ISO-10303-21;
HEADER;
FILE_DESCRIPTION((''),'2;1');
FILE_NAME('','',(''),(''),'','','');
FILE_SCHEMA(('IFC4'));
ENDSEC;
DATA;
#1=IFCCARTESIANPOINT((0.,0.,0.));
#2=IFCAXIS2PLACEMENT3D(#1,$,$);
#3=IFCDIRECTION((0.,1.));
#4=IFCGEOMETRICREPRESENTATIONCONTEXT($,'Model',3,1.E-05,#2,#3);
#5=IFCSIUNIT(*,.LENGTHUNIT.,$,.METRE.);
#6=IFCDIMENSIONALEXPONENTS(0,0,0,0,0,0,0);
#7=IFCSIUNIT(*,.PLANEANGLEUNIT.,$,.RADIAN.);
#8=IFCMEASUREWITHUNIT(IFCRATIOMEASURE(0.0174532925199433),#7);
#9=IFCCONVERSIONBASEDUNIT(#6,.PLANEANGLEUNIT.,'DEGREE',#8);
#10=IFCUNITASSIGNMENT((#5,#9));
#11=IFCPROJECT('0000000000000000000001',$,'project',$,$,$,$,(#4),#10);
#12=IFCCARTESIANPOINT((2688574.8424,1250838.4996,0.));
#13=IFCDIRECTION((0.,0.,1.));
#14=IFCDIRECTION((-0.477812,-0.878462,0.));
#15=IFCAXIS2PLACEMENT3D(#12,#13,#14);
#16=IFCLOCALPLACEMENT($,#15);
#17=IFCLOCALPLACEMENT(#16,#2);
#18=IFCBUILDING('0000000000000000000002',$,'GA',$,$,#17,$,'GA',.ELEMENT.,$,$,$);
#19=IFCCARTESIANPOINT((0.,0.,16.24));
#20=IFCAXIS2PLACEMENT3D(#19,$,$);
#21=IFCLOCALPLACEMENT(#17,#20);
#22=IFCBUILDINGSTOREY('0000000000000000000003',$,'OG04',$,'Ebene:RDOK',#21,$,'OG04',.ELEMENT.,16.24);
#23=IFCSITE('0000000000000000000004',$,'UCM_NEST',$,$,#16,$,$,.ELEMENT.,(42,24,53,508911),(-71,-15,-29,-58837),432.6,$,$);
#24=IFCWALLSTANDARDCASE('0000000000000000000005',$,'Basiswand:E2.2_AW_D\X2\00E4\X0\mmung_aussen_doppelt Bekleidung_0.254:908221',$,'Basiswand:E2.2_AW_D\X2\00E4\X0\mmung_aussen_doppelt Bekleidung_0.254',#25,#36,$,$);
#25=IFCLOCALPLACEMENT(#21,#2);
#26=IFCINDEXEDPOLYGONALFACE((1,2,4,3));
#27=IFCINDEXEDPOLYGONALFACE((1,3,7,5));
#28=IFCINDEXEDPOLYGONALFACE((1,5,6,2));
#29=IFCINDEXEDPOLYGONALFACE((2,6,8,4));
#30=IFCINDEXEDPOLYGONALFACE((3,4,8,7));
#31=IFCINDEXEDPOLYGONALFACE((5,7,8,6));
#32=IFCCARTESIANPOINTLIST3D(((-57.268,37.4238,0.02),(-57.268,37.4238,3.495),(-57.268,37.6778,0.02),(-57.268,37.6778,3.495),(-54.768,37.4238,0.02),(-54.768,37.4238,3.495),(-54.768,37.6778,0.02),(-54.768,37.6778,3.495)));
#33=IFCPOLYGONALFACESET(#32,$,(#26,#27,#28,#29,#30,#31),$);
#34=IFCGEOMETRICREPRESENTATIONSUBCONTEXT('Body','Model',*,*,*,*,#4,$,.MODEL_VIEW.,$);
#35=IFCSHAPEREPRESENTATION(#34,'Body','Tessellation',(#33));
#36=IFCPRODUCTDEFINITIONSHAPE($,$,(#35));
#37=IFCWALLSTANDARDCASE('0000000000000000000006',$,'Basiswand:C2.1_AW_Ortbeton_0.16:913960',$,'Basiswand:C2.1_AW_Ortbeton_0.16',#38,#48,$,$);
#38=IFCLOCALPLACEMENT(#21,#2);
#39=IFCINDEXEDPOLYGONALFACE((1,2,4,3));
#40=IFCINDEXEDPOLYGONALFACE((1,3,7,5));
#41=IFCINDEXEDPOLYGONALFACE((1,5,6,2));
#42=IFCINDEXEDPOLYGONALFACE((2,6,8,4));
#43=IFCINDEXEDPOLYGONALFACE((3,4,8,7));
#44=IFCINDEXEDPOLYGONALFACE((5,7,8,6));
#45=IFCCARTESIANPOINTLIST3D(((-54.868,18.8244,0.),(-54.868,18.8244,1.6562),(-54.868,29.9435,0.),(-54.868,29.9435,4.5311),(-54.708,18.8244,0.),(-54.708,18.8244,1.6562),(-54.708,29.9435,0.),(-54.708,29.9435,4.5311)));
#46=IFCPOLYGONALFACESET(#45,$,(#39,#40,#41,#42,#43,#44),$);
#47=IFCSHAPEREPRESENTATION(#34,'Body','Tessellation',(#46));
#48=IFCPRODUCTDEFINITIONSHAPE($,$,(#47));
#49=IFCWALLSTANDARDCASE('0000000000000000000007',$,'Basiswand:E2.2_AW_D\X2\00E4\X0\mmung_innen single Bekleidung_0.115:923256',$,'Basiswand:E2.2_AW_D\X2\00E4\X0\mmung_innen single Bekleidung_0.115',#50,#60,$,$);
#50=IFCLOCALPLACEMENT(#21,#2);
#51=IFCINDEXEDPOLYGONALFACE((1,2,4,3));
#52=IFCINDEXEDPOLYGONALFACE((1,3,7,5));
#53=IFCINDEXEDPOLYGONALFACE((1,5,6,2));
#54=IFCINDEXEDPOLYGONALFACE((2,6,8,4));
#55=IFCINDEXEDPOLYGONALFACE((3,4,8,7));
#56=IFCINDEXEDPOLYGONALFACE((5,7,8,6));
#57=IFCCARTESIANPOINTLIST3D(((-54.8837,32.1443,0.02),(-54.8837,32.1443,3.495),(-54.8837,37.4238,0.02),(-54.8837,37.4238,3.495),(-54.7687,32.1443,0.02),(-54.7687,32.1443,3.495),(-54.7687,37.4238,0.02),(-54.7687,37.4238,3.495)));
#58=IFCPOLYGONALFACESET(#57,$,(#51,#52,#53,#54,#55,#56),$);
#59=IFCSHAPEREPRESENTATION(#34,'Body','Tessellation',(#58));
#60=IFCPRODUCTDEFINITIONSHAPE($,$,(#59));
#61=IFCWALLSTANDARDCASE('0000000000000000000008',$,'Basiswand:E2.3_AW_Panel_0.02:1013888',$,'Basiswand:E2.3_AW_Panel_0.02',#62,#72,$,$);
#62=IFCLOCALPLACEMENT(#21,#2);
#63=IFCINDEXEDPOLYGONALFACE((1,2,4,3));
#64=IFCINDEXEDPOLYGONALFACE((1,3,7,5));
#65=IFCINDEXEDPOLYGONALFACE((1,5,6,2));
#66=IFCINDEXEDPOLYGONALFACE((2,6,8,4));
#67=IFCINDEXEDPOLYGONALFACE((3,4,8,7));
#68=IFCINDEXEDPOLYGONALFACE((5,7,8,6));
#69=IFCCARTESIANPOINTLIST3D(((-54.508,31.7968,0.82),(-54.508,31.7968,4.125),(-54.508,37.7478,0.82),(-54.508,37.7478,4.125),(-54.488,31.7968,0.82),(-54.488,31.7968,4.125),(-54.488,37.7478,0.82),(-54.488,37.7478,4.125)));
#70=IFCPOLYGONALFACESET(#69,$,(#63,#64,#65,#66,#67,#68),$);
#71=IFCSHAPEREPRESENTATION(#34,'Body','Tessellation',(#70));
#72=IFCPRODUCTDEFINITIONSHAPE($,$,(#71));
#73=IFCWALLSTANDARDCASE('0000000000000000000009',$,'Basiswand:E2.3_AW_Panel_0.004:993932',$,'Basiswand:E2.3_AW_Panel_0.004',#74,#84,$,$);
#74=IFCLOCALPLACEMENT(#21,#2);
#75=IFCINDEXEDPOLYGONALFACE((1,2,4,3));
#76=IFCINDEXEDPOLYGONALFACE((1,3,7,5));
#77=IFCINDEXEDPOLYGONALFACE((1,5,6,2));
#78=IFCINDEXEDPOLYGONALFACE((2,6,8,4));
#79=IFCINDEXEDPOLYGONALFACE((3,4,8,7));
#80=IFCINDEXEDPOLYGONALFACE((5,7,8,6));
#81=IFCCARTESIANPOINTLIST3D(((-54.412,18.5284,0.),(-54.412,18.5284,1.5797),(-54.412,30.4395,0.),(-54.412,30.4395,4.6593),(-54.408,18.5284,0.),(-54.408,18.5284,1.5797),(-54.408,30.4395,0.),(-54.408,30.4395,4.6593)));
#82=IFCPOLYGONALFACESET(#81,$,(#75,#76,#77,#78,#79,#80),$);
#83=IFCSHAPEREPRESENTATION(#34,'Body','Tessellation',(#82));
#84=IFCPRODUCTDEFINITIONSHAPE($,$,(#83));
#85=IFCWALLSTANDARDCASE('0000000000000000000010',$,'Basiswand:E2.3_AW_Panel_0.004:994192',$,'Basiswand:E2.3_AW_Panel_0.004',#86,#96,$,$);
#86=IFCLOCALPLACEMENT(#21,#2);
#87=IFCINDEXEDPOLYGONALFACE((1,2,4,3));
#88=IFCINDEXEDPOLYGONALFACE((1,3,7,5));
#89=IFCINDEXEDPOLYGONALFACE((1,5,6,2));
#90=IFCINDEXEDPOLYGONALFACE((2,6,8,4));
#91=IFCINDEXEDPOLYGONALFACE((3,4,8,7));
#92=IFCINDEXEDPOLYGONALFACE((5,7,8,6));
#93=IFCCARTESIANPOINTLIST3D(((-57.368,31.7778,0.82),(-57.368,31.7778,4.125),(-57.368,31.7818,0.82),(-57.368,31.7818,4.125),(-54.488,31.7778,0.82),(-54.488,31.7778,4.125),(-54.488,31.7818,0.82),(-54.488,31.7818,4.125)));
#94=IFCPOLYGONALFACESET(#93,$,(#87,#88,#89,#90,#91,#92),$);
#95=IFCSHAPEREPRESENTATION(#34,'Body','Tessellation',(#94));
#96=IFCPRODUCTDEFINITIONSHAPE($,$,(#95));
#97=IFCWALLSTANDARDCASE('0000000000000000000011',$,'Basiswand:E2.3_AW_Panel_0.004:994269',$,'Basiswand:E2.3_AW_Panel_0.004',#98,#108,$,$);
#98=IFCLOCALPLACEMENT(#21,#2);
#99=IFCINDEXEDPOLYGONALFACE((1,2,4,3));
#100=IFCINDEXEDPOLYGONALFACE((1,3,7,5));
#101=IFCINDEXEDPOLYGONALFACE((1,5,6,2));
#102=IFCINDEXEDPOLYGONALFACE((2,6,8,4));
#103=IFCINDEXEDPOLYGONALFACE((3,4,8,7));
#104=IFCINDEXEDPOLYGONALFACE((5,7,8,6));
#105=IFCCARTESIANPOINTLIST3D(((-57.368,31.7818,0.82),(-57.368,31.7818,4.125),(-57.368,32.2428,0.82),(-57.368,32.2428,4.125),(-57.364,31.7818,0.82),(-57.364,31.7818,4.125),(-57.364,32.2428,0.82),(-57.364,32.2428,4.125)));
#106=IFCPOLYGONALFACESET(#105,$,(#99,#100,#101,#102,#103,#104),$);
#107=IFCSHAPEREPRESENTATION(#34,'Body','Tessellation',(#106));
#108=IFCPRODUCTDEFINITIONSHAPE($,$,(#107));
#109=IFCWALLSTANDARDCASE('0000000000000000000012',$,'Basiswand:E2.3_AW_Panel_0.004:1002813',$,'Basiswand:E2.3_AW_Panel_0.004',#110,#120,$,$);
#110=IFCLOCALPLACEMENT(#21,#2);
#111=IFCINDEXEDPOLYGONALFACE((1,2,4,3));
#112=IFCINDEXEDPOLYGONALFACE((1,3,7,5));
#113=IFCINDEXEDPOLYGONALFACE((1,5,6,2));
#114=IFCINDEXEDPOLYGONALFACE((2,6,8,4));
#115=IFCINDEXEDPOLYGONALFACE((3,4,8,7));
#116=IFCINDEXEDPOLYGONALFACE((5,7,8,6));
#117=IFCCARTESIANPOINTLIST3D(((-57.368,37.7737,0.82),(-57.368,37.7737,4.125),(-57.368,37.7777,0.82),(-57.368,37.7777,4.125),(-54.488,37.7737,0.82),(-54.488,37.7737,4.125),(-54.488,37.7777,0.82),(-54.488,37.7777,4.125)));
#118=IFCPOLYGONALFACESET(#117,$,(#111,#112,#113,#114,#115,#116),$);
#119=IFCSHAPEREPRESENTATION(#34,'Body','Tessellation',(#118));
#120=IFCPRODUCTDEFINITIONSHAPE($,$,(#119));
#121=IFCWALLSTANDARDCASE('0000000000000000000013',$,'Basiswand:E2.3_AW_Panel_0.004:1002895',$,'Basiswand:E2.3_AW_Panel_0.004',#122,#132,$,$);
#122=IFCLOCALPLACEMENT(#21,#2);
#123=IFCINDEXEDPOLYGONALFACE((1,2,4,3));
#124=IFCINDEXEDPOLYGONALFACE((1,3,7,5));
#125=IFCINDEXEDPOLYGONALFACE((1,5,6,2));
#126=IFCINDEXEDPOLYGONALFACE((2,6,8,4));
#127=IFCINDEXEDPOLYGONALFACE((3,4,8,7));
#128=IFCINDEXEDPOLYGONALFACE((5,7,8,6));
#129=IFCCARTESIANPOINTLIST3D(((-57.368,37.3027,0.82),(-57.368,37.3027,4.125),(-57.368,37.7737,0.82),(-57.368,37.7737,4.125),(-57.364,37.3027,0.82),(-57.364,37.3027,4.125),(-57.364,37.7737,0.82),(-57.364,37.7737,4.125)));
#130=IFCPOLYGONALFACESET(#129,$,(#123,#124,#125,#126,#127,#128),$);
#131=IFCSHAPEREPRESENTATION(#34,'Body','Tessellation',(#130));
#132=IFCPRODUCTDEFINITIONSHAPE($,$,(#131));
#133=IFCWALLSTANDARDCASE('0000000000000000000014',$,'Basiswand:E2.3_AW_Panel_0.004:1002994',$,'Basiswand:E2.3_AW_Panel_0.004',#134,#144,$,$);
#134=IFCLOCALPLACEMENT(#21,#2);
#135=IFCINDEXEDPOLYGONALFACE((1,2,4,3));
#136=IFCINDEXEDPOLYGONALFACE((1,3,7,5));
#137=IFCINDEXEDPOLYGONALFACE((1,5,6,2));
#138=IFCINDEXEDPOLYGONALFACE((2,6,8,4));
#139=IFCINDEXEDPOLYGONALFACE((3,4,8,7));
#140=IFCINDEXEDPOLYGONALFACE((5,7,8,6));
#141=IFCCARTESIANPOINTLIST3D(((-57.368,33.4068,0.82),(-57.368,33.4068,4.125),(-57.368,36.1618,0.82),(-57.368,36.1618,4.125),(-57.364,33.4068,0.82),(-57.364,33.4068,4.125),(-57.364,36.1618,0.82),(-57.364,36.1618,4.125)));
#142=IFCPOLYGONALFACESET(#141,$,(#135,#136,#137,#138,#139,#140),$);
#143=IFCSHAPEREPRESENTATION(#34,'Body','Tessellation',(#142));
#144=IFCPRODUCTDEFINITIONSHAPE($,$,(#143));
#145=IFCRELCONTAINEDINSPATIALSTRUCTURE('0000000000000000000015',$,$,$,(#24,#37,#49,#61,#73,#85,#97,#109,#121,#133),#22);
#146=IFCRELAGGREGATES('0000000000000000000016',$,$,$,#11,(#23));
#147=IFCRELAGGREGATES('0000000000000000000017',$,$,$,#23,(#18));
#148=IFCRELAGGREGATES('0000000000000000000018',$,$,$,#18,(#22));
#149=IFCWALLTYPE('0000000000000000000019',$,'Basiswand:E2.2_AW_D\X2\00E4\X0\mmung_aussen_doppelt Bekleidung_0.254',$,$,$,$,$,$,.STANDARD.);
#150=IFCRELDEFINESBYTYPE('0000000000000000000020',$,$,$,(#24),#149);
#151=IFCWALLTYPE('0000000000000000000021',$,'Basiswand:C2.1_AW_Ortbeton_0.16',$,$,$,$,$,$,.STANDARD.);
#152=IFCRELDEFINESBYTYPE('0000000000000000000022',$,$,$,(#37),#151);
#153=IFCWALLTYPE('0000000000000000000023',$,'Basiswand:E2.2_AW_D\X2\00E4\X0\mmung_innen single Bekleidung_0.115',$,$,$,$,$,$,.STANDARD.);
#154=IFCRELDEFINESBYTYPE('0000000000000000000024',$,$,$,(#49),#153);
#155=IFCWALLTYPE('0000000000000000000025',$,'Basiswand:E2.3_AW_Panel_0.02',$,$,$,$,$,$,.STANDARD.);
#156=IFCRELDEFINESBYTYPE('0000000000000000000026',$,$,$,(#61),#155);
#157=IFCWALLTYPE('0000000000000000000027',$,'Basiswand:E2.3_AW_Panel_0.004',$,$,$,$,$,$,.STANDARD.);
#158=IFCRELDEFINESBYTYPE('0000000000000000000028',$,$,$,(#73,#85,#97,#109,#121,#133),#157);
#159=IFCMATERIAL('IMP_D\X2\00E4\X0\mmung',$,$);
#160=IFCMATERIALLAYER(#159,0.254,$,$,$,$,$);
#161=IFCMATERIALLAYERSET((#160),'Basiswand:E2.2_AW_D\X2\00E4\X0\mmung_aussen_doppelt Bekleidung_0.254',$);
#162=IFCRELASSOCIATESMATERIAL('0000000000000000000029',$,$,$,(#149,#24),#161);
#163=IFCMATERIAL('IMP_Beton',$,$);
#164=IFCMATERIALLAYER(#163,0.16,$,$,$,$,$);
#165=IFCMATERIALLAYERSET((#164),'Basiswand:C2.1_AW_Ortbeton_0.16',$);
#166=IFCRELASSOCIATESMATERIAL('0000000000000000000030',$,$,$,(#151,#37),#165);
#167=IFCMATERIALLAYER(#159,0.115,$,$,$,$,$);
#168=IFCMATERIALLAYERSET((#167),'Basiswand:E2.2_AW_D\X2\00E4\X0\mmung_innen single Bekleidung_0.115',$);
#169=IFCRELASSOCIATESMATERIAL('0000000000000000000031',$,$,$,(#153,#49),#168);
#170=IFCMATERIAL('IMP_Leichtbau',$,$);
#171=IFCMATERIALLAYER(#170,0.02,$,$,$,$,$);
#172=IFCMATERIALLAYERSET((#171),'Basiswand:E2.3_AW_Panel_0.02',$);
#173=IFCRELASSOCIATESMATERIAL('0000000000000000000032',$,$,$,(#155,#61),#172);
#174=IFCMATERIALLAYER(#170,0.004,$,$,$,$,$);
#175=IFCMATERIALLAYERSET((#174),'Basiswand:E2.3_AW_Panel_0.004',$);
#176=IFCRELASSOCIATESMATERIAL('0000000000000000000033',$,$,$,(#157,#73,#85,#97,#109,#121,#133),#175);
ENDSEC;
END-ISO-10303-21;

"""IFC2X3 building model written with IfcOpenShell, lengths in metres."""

from ifc_helpers import new_model, entity, si_unit, converted_unit, direction, frame, frame_2d, origin, place, context, subcontext, project, spatial, rectangle, extrude, clip, halfspace, material, layer, layer_set, layer_usage, type_object, element, save


model = new_model("IFC2X3")

# Units and contexts
model_context = context("Model", 3, precision=1e-05, world=origin(), true_north=direction((0.0, 1.0)))
body_context = subcontext(model_context, "Body", "Model", "MODEL_VIEW")
ifc_project = project(units=[si_unit("LENGTHUNIT", "METRE"), converted_unit("PLANEANGLEUNIT", "DEGREE", entity("IfcRatioMeasure", 0.0174532925199433), si_unit("PLANEANGLEUNIT", "RADIAN"), dimensions=[0, 0, 0, 0, 0, 0, 0])], contexts=[model_context])

# Site, building, storey
site_placement = place(None, frame((2688574.8424, 1250838.4996, 0.0), z_axis=(0.0, 0.0, 1.0), x_axis=(-0.477812, -0.878462, 0.0)))
site = spatial("IfcSite", under=ifc_project, at=site_placement, Name="UCM_NEST", CompositionType="ELEMENT", RefLatitude=(42, 24, 53, 508911), RefLongitude=(-71, -15, -29, -58837), RefElevation=432.6)
building_placement = place(site_placement, origin())
building = spatial("IfcBuilding", under=site, at=building_placement, Name="GA", LongName="GA", CompositionType="ELEMENT")
storey_placement = place(building_placement, frame((0.0, 0.0, 16.24)))
storey = spatial("IfcBuildingStorey", under=building, at=storey_placement, Name="OG04", ObjectType="Ebene:RDOK", LongName="OG04", CompositionType="ELEMENT", Elevation=16.24)

# Shared definitions
ifc_material_1 = material(Name="IMP_Dämmung")

# Walls
ifc_layer_1 = layer(ifc_material_1, 0.254)
ifc_layer_set_1 = layer_set([ifc_layer_1], Name="Basiswand:E2.2_AW_Dämmung_aussen_doppelt Bekleidung_0.254")
ifc_layer_usage_1 = layer_usage(ifc_layer_set_1, "AXIS2", "NEGATIVE", 0.127)
wall_type_1 = type_object("IfcWallType", Name="Basiswand:E2.2_AW_Dämmung_aussen_doppelt Bekleidung_0.254", PredefinedType="STANDARD", material=ifc_layer_set_1)
wall_1_placement = place(storey_placement, frame((-57.268, 37.5508, 0.02)))
element("IfcWallStandardCase", 1, at=wall_1_placement, inside=storey, type_object=wall_type_1, material=ifc_layer_usage_1, Name="Basiswand:E2.2_AW_Dämmung_aussen_doppelt Bekleidung_0.254:908221", ObjectType="Basiswand:E2.2_AW_Dämmung_aussen_doppelt Bekleidung_0.254", context=body_context, shape_type="SweptSolid", body=[
    extrude(rectangle(XDim=2.5, YDim=0.254, at=frame_2d((1.25, 0.0), x_axis=(-1.0, 0.0))), origin(), (0.0, 0.0, 1.0), 3.475),
])
ifc_material_2 = material(Name="IMP_Beton")
ifc_layer_2 = layer(ifc_material_2, 0.16)
ifc_layer_set_2 = layer_set([ifc_layer_2], Name="Basiswand:C2.1_AW_Ortbeton_0.16")
ifc_layer_usage_2 = layer_usage(ifc_layer_set_2, "AXIS2", "NEGATIVE", 0.08)
wall_type_2 = type_object("IfcWallType", Name="Basiswand:C2.1_AW_Ortbeton_0.16", PredefinedType="STANDARD", material=ifc_layer_set_2)
wall_2_placement = place(storey_placement, frame((-54.788, 29.9435, 0.0), z_axis=(0.0, 0.0, 1.0), x_axis=(0.0, -1.0, 0.0)))
element("IfcWallStandardCase", 2, at=wall_2_placement, inside=storey, type_object=wall_type_2, material=ifc_layer_usage_2, Name="Basiswand:C2.1_AW_Ortbeton_0.16:913960", ObjectType="Basiswand:C2.1_AW_Ortbeton_0.16", context=body_context, shape_type="Clipping", body=[
    clip(extrude(rectangle(XDim=11.119, YDim=0.16, at=frame_2d((5.5595, 0.0), x_axis=(-1.0, 0.0))), origin(), (0.0, 0.0, 1.0), 4.5311), halfspace(frame((0.0, -0.08, 4.5311), z_axis=(0.250322, 0.0, 0.968163), x_axis=(0.0, 1.0, 0.0)), False)),
])
ifc_layer_3 = layer(ifc_material_1, 0.115)
ifc_layer_set_3 = layer_set([ifc_layer_3], Name="Basiswand:E2.2_AW_Dämmung_innen single Bekleidung_0.115")
ifc_layer_usage_3 = layer_usage(ifc_layer_set_3, "AXIS2", "NEGATIVE", 0.0575)
wall_type_3 = type_object("IfcWallType", Name="Basiswand:E2.2_AW_Dämmung_innen single Bekleidung_0.115", PredefinedType="STANDARD", material=ifc_layer_set_3)
wall_3_placement = place(storey_placement, frame((-54.8262, 37.4238, 0.02), z_axis=(0.0, 0.0, 1.0), x_axis=(0.0, -1.0, 0.0)))
element("IfcWallStandardCase", 3, at=wall_3_placement, inside=storey, type_object=wall_type_3, material=ifc_layer_usage_3, Name="Basiswand:E2.2_AW_Dämmung_innen single Bekleidung_0.115:923256", ObjectType="Basiswand:E2.2_AW_Dämmung_innen single Bekleidung_0.115", context=body_context, shape_type="SweptSolid", body=[
    extrude(rectangle(XDim=5.2795, YDim=0.115, at=frame_2d((2.6397, 0.0), x_axis=(-1.0, 0.0))), origin(), (0.0, 0.0, 1.0), 3.475),
])
ifc_material_3 = material(Name="IMP_Leichtbau")
ifc_layer_4 = layer(ifc_material_3, 0.02)
ifc_layer_set_4 = layer_set([ifc_layer_4], Name="Basiswand:E2.3_AW_Panel_0.02")
ifc_layer_usage_4 = layer_usage(ifc_layer_set_4, "AXIS2", "NEGATIVE", 0.01)
wall_type_4 = type_object("IfcWallType", Name="Basiswand:E2.3_AW_Panel_0.02", PredefinedType="STANDARD", material=ifc_layer_set_4)
wall_4_placement = place(storey_placement, frame((-54.498, 37.7478, 0.82), z_axis=(0.0, 0.0, 1.0), x_axis=(0.0, -1.0, 0.0)))
element("IfcWallStandardCase", 4, at=wall_4_placement, inside=storey, type_object=wall_type_4, material=ifc_layer_usage_4, Name="Basiswand:E2.3_AW_Panel_0.02:1013888", ObjectType="Basiswand:E2.3_AW_Panel_0.02", context=body_context, shape_type="SweptSolid", body=[
    extrude(rectangle(XDim=5.951, YDim=0.02, at=frame_2d((2.9755, 0.0), x_axis=(-1.0, 0.0))), origin(), (0.0, 0.0, 1.0), 3.305),
])
ifc_layer_5 = layer(ifc_material_3, 0.004)
ifc_layer_set_5 = layer_set([ifc_layer_5], Name="Basiswand:E2.3_AW_Panel_0.004")
ifc_layer_usage_5 = layer_usage(ifc_layer_set_5, "AXIS2", "NEGATIVE", 0.002)
wall_type_5 = type_object("IfcWallType", Name="Basiswand:E2.3_AW_Panel_0.004", PredefinedType="STANDARD", material=ifc_layer_set_5)
wall_5_placement = place(storey_placement, frame((-54.41, 30.4395, 0.0), z_axis=(0.0, 0.0, 1.0), x_axis=(0.0, -1.0, 0.0)))
element("IfcWallStandardCase", 5, at=wall_5_placement, inside=storey, type_object=wall_type_5, material=ifc_layer_usage_5, Name="Basiswand:E2.3_AW_Panel_0.004:993932", ObjectType="Basiswand:E2.3_AW_Panel_0.004", context=body_context, shape_type="Clipping", body=[
    clip(extrude(rectangle(XDim=11.911, YDim=0.004, at=frame_2d((5.9555, 0.0), x_axis=(-1.0, 0.0))), origin(), (0.0, 0.0, 1.0), 4.6593), halfspace(frame((0.0, -0.002, 4.6593), z_axis=(0.250322, 0.0, 0.968163), x_axis=(0.0, 1.0, 0.0)), False)),
])
ifc_layer_usage_6 = layer_usage(ifc_layer_set_5, "AXIS2", "NEGATIVE", 0.002)
wall_6_placement = place(storey_placement, frame((-54.488, 31.7798, 0.82), z_axis=(0.0, 0.0, 1.0), x_axis=(-1.0, 0.0, 0.0)))
element("IfcWallStandardCase", 6, at=wall_6_placement, inside=storey, type_object=wall_type_5, material=ifc_layer_usage_6, Name="Basiswand:E2.3_AW_Panel_0.004:994192", ObjectType="Basiswand:E2.3_AW_Panel_0.004", context=body_context, shape_type="SweptSolid", body=[
    extrude(rectangle(XDim=2.88, YDim=0.004, at=frame_2d((1.44, 0.0), x_axis=(-1.0, 0.0))), origin(), (0.0, 0.0, 1.0), 3.305),
])
ifc_layer_usage_7 = layer_usage(ifc_layer_set_5, "AXIS2", "NEGATIVE", 0.002)
wall_7_placement = place(storey_placement, frame((-57.366, 31.7818, 0.82), z_axis=(0.0, 0.0, 1.0), x_axis=(0.0, 1.0, 0.0)))
element("IfcWallStandardCase", 7, at=wall_7_placement, inside=storey, type_object=wall_type_5, material=ifc_layer_usage_7, Name="Basiswand:E2.3_AW_Panel_0.004:994269", ObjectType="Basiswand:E2.3_AW_Panel_0.004", context=body_context, shape_type="SweptSolid", body=[
    extrude(rectangle(XDim=0.461, YDim=0.004, at=frame_2d((0.2305, 0.0), x_axis=(-1.0, 0.0))), origin(), (0.0, 0.0, 1.0), 3.305),
])
ifc_layer_usage_8 = layer_usage(ifc_layer_set_5, "AXIS2", "NEGATIVE", 0.002)
wall_8_placement = place(storey_placement, frame((-54.488, 37.7757, 0.82), z_axis=(0.0, 0.0, 1.0), x_axis=(-1.0, 0.0, 0.0)))
element("IfcWallStandardCase", 8, at=wall_8_placement, inside=storey, type_object=wall_type_5, material=ifc_layer_usage_8, Name="Basiswand:E2.3_AW_Panel_0.004:1002813", ObjectType="Basiswand:E2.3_AW_Panel_0.004", context=body_context, shape_type="SweptSolid", body=[
    extrude(rectangle(XDim=2.88, YDim=0.004, at=frame_2d((1.44, 0.0), x_axis=(-1.0, 0.0))), origin(), (0.0, 0.0, 1.0), 3.305),
])
ifc_layer_usage_9 = layer_usage(ifc_layer_set_5, "AXIS2", "NEGATIVE", 0.002)
wall_9_placement = place(storey_placement, frame((-57.366, 37.7737, 0.82), z_axis=(0.0, 0.0, 1.0), x_axis=(0.0, -1.0, 0.0)))
element("IfcWallStandardCase", 9, at=wall_9_placement, inside=storey, type_object=wall_type_5, material=ifc_layer_usage_9, Name="Basiswand:E2.3_AW_Panel_0.004:1002895", ObjectType="Basiswand:E2.3_AW_Panel_0.004", context=body_context, shape_type="SweptSolid", body=[
    extrude(rectangle(XDim=0.471, YDim=0.004, at=frame_2d((0.2355, 0.0), x_axis=(-1.0, 0.0))), origin(), (0.0, 0.0, 1.0), 3.305),
])
ifc_layer_usage_10 = layer_usage(ifc_layer_set_5, "AXIS2", "NEGATIVE", 0.002)
wall_10_placement = place(storey_placement, frame((-57.366, 36.1618, 0.82), z_axis=(0.0, 0.0, 1.0), x_axis=(0.0, -1.0, 0.0)))
element("IfcWallStandardCase", 10, at=wall_10_placement, inside=storey, type_object=wall_type_5, material=ifc_layer_usage_10, Name="Basiswand:E2.3_AW_Panel_0.004:1002994", ObjectType="Basiswand:E2.3_AW_Panel_0.004", context=body_context, shape_type="SweptSolid", body=[
    extrude(rectangle(XDim=2.755, YDim=0.004, at=frame_2d((1.3775, 0.0), x_axis=(-1.0, 0.0))), origin(), (0.0, 0.0, 1.0), 3.305),
])

save(model, "model.ifc")
